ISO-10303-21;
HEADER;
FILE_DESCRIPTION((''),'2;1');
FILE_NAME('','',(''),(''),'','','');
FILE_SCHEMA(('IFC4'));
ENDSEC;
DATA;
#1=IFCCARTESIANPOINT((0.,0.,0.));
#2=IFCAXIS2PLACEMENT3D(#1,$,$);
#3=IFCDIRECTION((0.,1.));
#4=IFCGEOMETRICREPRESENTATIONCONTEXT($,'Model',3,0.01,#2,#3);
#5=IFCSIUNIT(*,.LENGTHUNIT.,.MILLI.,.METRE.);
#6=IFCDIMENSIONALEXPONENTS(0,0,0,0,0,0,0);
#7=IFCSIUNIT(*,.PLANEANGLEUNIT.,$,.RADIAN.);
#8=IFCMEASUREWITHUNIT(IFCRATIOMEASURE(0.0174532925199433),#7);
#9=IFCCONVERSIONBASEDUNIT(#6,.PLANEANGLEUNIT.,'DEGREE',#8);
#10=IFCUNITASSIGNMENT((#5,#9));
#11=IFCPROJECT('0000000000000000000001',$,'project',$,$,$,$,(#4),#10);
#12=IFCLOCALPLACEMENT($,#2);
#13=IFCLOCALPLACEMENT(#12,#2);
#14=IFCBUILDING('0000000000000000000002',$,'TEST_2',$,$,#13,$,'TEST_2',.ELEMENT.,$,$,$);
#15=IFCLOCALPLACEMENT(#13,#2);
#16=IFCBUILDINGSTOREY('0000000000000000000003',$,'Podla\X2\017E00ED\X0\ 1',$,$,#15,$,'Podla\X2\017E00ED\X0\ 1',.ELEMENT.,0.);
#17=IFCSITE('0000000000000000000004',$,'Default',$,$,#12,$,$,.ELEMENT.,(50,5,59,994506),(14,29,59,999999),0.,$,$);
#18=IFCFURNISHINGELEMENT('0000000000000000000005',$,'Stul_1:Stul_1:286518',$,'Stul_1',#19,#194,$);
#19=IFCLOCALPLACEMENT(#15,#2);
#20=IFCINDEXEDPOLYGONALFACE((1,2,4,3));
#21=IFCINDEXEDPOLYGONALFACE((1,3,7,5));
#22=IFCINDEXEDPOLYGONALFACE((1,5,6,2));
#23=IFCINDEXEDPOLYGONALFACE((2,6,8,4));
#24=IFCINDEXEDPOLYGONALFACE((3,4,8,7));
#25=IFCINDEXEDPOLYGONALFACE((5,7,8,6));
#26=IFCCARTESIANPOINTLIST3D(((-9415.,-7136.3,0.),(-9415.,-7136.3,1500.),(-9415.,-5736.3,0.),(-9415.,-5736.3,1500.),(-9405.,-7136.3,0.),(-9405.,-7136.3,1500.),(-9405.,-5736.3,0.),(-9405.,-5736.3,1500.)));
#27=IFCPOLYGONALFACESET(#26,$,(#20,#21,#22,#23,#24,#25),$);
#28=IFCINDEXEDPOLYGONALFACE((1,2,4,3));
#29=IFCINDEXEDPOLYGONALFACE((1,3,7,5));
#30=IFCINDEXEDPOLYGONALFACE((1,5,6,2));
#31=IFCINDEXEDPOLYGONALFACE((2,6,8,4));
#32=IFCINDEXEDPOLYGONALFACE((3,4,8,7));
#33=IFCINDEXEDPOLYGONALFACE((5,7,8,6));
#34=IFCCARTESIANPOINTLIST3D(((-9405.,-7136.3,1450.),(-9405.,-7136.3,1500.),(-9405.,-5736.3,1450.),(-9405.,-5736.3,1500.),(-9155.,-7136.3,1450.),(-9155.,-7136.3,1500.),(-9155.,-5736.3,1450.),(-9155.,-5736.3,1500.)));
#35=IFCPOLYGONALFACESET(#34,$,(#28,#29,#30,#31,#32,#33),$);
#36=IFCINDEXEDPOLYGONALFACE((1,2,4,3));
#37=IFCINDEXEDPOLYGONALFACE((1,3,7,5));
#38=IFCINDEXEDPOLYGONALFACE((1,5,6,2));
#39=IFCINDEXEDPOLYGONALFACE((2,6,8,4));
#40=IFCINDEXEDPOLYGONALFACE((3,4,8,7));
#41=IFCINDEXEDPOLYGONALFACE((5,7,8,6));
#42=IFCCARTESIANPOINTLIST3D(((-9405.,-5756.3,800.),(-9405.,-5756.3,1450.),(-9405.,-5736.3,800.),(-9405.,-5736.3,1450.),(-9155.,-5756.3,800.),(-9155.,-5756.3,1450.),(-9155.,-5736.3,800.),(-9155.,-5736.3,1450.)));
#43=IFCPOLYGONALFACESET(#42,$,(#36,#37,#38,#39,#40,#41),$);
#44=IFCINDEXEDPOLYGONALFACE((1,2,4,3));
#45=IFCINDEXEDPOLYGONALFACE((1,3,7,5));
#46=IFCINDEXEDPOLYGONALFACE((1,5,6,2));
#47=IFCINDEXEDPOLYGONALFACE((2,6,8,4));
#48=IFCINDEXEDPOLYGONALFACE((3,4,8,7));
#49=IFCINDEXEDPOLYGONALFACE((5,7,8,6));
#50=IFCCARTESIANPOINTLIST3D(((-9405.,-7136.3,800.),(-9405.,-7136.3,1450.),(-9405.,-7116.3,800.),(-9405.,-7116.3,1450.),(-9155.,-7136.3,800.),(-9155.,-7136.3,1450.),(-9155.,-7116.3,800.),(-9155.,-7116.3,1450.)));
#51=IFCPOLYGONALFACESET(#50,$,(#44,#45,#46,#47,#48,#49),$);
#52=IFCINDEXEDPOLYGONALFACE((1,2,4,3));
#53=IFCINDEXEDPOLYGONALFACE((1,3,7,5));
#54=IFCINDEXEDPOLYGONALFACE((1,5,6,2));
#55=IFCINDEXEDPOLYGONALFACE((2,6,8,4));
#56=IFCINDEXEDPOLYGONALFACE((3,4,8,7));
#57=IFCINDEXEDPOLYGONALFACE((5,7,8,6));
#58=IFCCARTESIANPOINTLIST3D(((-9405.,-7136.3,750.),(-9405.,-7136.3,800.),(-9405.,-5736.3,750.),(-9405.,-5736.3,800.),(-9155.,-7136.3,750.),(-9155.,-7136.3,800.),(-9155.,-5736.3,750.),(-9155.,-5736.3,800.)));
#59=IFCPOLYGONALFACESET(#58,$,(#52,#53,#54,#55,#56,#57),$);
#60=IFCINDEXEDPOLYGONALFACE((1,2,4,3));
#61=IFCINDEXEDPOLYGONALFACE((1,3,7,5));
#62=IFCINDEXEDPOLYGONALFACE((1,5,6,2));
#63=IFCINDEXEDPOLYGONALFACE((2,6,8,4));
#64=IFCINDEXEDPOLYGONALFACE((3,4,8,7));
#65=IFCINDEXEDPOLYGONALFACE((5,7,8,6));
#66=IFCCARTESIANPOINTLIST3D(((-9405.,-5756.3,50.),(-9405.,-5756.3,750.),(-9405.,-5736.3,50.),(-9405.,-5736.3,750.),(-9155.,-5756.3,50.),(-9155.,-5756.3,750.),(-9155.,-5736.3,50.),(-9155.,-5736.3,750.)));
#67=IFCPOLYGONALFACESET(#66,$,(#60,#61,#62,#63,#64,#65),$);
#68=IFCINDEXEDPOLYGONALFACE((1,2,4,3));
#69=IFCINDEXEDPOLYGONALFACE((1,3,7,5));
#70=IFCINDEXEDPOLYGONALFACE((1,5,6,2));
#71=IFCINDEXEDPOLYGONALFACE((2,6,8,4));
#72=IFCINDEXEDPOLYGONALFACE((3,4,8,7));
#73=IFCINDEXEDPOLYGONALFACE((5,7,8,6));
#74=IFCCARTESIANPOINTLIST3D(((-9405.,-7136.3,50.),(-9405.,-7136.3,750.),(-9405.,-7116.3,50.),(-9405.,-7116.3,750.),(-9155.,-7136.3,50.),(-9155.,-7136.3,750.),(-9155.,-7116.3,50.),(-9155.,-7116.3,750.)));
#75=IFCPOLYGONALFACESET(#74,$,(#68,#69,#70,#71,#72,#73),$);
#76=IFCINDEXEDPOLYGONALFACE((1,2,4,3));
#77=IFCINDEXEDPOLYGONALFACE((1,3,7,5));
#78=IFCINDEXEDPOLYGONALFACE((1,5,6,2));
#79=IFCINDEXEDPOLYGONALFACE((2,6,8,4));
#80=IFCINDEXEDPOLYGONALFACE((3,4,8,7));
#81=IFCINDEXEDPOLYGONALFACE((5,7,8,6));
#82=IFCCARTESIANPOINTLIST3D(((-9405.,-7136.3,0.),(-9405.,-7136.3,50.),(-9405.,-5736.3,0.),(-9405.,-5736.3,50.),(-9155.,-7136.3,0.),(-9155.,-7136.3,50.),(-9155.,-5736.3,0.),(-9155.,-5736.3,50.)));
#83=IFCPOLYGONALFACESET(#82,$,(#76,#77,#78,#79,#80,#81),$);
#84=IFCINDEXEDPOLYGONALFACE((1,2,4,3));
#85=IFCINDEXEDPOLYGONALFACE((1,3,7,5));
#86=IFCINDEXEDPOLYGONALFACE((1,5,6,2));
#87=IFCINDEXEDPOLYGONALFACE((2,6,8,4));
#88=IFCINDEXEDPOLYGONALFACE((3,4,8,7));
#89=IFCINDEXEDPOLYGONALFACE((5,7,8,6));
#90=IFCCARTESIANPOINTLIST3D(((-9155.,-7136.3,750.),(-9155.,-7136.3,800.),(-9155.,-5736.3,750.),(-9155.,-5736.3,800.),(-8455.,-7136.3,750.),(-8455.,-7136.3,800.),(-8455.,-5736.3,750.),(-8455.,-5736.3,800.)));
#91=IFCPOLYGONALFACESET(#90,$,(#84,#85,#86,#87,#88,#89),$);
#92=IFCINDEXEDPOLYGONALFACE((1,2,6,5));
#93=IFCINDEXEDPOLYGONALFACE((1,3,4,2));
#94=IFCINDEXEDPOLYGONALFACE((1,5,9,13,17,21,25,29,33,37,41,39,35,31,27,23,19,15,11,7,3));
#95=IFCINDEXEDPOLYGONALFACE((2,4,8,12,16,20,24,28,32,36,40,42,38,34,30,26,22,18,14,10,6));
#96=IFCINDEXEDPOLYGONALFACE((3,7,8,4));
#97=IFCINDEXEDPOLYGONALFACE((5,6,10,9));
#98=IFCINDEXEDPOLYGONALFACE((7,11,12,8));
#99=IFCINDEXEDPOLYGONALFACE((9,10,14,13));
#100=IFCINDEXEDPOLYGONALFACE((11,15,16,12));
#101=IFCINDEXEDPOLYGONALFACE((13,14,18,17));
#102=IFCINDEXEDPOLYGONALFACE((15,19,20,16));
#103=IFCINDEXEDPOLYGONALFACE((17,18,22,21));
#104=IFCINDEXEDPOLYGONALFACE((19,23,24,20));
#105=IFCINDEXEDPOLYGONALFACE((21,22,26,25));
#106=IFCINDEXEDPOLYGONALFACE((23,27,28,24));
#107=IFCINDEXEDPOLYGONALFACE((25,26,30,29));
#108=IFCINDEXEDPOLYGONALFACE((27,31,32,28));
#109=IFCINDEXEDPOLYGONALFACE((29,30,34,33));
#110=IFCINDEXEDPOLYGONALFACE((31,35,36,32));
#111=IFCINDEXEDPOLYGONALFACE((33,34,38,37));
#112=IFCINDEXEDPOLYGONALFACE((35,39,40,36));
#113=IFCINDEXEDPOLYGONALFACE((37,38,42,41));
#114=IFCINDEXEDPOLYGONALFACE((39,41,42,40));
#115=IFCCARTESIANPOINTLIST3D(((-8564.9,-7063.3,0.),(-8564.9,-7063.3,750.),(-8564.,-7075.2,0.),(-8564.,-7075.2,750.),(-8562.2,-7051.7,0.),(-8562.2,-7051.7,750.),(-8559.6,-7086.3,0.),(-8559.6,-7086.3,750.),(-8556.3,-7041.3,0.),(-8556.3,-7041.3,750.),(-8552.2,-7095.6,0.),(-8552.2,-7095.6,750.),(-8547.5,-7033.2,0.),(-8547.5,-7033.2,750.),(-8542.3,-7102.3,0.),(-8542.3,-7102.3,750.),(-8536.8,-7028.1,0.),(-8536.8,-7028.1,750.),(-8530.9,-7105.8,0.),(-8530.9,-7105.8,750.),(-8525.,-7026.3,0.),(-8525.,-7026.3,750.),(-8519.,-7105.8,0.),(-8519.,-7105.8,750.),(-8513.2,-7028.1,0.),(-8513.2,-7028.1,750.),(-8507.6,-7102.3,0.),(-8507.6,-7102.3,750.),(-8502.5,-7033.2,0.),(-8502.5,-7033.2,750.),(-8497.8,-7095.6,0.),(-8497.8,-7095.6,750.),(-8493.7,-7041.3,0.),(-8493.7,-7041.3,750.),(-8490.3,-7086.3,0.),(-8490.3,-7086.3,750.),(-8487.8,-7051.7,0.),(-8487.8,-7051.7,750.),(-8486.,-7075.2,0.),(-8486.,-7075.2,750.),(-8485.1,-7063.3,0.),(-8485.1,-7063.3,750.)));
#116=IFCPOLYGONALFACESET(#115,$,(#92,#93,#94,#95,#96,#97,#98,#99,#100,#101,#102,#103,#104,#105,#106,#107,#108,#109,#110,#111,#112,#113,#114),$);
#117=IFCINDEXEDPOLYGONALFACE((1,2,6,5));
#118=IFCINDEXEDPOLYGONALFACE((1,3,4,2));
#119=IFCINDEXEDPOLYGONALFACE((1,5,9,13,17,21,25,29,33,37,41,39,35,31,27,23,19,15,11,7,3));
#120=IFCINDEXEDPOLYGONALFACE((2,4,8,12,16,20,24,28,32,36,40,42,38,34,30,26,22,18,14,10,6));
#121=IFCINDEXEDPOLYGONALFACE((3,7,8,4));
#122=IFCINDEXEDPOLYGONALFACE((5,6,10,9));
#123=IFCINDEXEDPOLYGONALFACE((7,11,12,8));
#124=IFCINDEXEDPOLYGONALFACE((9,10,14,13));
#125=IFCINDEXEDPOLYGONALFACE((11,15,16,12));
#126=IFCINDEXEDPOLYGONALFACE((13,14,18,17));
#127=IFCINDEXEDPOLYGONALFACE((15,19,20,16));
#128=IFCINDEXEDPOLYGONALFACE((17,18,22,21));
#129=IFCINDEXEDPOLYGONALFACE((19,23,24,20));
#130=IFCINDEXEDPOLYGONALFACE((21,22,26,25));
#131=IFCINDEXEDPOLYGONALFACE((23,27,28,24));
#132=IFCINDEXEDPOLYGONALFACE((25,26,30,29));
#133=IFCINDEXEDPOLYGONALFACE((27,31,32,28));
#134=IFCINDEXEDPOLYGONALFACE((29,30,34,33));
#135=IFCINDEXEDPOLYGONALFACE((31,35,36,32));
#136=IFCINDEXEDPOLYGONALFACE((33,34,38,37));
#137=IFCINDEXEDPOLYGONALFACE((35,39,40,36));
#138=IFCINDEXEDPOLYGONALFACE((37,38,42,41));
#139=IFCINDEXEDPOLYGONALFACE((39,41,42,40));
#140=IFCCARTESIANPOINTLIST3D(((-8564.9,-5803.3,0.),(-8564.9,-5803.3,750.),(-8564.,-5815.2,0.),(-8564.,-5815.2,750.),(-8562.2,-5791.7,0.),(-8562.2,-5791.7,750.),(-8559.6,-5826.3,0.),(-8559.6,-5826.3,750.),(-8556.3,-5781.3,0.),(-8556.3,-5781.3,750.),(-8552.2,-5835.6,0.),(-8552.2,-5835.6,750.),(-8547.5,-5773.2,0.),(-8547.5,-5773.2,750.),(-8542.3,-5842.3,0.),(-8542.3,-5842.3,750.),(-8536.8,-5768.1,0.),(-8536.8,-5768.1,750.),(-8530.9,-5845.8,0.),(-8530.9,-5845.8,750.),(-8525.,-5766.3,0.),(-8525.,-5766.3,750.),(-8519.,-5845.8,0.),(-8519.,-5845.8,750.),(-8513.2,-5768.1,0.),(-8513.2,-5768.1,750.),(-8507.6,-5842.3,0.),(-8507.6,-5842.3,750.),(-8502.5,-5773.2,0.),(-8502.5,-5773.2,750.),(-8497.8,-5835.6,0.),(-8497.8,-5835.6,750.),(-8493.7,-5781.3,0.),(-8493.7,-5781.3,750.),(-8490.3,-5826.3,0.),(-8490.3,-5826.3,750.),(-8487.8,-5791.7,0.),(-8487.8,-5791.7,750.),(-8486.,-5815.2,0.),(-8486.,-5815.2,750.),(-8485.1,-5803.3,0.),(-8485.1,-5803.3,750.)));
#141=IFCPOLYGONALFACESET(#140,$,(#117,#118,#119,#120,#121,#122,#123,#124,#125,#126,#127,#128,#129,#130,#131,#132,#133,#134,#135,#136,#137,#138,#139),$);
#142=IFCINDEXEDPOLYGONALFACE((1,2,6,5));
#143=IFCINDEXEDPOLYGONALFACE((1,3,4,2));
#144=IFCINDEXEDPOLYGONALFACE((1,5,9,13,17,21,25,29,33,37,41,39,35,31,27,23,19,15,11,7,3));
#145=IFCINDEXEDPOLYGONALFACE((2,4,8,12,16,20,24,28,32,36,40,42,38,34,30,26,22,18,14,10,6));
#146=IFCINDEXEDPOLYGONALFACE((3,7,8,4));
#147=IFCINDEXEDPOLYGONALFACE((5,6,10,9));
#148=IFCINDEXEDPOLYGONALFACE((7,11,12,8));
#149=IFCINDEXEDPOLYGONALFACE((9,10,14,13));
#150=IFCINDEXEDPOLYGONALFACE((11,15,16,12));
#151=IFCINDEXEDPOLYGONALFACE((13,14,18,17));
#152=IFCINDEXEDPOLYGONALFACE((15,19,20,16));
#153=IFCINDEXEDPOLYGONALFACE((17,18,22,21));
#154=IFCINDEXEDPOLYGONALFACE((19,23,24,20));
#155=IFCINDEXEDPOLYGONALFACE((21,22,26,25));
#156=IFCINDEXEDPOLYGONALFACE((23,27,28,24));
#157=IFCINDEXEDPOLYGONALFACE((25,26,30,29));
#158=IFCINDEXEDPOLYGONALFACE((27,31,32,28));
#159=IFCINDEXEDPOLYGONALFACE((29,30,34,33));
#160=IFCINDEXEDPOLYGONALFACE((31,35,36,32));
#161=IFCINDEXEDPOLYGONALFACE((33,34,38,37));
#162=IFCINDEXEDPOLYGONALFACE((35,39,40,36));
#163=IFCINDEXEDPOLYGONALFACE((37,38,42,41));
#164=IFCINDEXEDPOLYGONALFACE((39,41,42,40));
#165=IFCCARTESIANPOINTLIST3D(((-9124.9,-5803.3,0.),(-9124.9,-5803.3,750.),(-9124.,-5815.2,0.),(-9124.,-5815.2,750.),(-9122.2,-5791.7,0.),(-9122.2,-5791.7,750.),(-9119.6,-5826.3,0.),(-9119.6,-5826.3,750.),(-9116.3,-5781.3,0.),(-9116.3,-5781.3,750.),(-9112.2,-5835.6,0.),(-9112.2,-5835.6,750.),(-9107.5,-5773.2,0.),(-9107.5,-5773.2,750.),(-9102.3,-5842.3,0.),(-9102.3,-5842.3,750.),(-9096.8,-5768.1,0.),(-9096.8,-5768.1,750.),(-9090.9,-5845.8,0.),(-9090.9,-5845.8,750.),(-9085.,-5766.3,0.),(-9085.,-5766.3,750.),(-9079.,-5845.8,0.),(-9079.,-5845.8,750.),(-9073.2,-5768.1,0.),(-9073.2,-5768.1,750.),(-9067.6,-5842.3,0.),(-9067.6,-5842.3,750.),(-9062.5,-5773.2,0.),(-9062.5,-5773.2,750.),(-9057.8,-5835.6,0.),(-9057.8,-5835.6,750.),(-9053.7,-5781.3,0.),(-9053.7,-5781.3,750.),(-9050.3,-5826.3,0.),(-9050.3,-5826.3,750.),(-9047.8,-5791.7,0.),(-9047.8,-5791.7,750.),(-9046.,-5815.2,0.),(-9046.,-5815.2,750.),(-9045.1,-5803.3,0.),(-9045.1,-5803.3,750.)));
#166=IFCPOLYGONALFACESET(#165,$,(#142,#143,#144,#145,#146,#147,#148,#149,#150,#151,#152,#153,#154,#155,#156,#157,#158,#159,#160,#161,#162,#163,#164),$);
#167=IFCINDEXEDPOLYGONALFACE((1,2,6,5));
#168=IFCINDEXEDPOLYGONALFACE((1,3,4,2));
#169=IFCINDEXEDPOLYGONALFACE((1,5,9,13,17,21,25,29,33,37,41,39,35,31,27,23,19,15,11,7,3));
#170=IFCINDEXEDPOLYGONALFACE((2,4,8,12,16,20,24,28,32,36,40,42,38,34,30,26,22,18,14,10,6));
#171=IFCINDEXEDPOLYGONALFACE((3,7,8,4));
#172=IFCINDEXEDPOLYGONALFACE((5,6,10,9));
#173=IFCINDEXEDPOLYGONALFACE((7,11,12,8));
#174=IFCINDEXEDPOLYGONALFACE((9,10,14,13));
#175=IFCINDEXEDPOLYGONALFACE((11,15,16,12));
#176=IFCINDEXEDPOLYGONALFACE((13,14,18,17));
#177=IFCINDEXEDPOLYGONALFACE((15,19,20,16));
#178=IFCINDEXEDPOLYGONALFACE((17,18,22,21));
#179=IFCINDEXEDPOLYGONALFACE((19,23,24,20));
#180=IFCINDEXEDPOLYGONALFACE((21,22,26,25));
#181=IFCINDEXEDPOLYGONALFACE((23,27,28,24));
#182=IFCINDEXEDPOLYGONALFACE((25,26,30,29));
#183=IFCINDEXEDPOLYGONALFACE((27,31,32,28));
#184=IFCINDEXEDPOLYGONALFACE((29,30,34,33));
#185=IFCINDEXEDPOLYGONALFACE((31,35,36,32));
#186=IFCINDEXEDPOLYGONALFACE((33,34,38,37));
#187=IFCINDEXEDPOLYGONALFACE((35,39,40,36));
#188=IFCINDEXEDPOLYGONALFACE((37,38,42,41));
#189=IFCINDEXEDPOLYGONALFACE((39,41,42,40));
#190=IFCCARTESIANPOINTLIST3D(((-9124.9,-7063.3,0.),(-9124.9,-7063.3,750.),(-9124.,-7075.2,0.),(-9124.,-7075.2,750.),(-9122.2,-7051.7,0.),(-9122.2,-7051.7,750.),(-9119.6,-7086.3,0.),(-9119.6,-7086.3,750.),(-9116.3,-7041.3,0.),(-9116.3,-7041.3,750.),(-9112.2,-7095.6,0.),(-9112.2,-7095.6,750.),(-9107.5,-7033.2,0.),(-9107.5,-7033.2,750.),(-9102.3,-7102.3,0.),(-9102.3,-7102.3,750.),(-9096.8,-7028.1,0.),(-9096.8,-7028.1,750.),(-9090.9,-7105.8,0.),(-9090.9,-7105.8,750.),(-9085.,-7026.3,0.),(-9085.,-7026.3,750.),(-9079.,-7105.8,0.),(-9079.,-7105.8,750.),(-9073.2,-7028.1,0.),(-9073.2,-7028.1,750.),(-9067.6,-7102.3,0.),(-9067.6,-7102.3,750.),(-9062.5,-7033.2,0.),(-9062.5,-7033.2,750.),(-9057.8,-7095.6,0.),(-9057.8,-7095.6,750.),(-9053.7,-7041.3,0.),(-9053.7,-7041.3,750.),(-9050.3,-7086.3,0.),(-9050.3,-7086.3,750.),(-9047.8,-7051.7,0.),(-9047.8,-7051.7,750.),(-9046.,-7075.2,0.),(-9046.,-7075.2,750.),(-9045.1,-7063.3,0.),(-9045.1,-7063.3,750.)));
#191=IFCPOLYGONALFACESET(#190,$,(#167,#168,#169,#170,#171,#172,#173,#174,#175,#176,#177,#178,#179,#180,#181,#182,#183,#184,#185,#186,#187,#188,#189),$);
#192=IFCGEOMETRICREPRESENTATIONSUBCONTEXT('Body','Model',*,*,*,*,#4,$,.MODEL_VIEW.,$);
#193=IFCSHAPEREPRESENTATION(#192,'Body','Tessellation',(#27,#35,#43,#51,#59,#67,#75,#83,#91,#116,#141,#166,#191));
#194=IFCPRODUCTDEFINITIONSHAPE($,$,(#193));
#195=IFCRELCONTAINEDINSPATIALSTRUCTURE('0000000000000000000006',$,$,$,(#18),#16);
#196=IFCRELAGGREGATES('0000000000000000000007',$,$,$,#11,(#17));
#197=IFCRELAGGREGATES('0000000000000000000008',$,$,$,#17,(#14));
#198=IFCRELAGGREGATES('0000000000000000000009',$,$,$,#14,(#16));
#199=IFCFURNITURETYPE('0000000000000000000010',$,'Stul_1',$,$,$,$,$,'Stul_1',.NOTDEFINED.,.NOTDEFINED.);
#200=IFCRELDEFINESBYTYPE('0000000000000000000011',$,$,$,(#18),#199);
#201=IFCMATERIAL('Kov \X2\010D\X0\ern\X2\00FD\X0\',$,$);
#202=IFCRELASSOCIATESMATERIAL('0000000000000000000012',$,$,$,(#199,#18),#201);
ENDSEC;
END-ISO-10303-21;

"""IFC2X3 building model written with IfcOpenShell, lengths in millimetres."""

from ifc_helpers import new_model, entity, si_unit, converted_unit, direction, frame, frame_2d, origin, origin_2d_with_axis, place, context, subcontext, project, spatial, rectangle, circle, extrude, source, transform, mapped, material, type_object, type_shapes, element, save


model = new_model("IFC2X3")

# Units and contexts
model_context = context("Model", 3, precision=0.01, world=origin(), true_north=direction((0.0, 1.0)))
body_context = subcontext(model_context, "Body", "Model", "MODEL_VIEW")
ifc_project = project(units=[si_unit("LENGTHUNIT", "METRE", prefix="MILLI"), converted_unit("PLANEANGLEUNIT", "DEGREE", entity("IfcRatioMeasure", 0.0174532925199433), si_unit("PLANEANGLEUNIT", "RADIAN"), dimensions=[0, 0, 0, 0, 0, 0, 0])], contexts=[model_context])

# Site, building, storey
site_placement = place(None, origin())
site = spatial("IfcSite", under=ifc_project, at=site_placement, Name="Default", CompositionType="ELEMENT", RefLatitude=(50, 5, 59, 994506), RefLongitude=(14, 29, 59, 999999), RefElevation=0.0)
building_placement = place(site_placement, origin())
building = spatial("IfcBuilding", under=site, at=building_placement, Name="TEST_2", LongName="TEST_2", CompositionType="ELEMENT")
storey_placement = place(building_placement, origin())
storey = spatial("IfcBuildingStorey", under=building, at=storey_placement, Name="Podlaží 1", LongName="Podlaží 1", CompositionType="ELEMENT", Elevation=0.0)

# Furnishing element
ifc_material_1 = material(Name="Kov černý")
furniture_type = type_object("IfcFurnitureType", Name="Stul_1", ElementType="Stul_1", material=ifc_material_1)
shared_shape_1 = source(origin(), body_context, "Body", "SweptSolid", [
    extrude(rectangle(XDim=1400.0, YDim=10.0, at=origin_2d_with_axis()), frame((0.0, 605.0, 0.0), z_axis=(0.0, 0.0, 1.0), x_axis=(-1.0, 0.0, 0.0)), (0.0, 0.0, 1.0), 1500.0),
    extrude(rectangle(XDim=1400.0, YDim=250.0, at=frame_2d((0.0, 0.0), x_axis=(1.0, 0.0))), frame((0.0, 475.0, 1450.0), z_axis=(0.0, 0.0, 1.0), x_axis=(-1.0, 0.0, 0.0)), (0.0, 0.0, 1.0), 50.0),
    extrude(rectangle(XDim=20.0, YDim=250.0, at=origin_2d_with_axis()), frame((690.0, 475.0, 800.0), z_axis=(0.0, 0.0, 1.0), x_axis=(-1.0, 0.0, 0.0)), (0.0, 0.0, 1.0), 650.0),
    extrude(rectangle(XDim=20.0, YDim=250.0, at=frame_2d((0.0, 0.0), x_axis=(1.0, 0.0))), frame((-690.0, 475.0, 800.0), z_axis=(0.0, 0.0, 1.0), x_axis=(-1.0, 0.0, 0.0)), (0.0, 0.0, 1.0), 650.0),
    extrude(rectangle(XDim=1400.0, YDim=250.0, at=origin_2d_with_axis()), frame((0.0, 475.0, 750.0), z_axis=(0.0, 0.0, 1.0), x_axis=(-1.0, 0.0, 0.0)), (0.0, 0.0, 1.0), 50.0),
    extrude(rectangle(XDim=20.0, YDim=250.0, at=origin_2d_with_axis()), frame((690.0, 475.0, 50.0), z_axis=(0.0, 0.0, 1.0), x_axis=(-1.0, 0.0, 0.0)), (0.0, 0.0, 1.0), 700.0),
    extrude(rectangle(XDim=20.0, YDim=250.0, at=frame_2d((0.0, 0.0), x_axis=(1.0, 0.0))), frame((-690.0, 475.0, 50.0), z_axis=(0.0, 0.0, 1.0), x_axis=(-1.0, 0.0, 0.0)), (0.0, 0.0, 1.0), 700.0),
    extrude(rectangle(XDim=1400.0, YDim=250.0, at=origin_2d_with_axis()), frame((0.0, 475.0, 0.0), z_axis=(0.0, 0.0, 1.0), x_axis=(-1.0, 0.0, 0.0)), (0.0, 0.0, 1.0), 50.0),
    extrude(rectangle(XDim=1400.0, YDim=700.0, at=origin_2d_with_axis()), frame((0.0, 0.0, 750.0), z_axis=(0.0, 0.0, 1.0), x_axis=(-1.0, 0.0, 0.0)), (0.0, 0.0, 1.0), 50.0),
    extrude(circle(Radius=40.0, at=frame_2d((0.0, 0.0), x_axis=(1.0, 0.0))), frame((-630.0, -280.0, 0.0)), (0.0, 0.0, 1.0), 750.0),
    extrude(circle(Radius=40.0, at=frame_2d((0.0, 0.0), x_axis=(1.0, 0.0))), frame((630.0, -280.0, 0.0)), (0.0, 0.0, 1.0), 750.0),
    extrude(circle(Radius=40.0, at=frame_2d((0.0, 0.0), x_axis=(1.0, 0.0))), frame((630.0, 280.0, 0.0)), (0.0, 0.0, 1.0), 750.0),
    extrude(circle(Radius=40.0, at=frame_2d((0.0, 0.0), x_axis=(1.0, 0.0))), frame((-630.0, 280.0, 0.0)), (0.0, 0.0, 1.0), 750.0),
])
type_shapes(furniture_type, [shared_shape_1])
for number, where, z_axis, x_axis, name in (
    (1, (-8805.0, -6436.3, 0.0), (0.0, 0.0, 1.0), (0.0, 1.0, 0.0), "Stul_1:Stul_1:286518"),
):
    element("IfcFurnishingElement", number, at=place(storey_placement, frame(where, z_axis=z_axis, x_axis=x_axis)), inside=storey, type_object=furniture_type, material=ifc_material_1, Name=name, ObjectType="Stul_1", context=body_context, shape_type="MappedRepresentation", body=[
        mapped(shared_shape_1, transform((0.0, 0.0, 0.0), scale=1.0)),
    ])

save(model, "model.ifc")
